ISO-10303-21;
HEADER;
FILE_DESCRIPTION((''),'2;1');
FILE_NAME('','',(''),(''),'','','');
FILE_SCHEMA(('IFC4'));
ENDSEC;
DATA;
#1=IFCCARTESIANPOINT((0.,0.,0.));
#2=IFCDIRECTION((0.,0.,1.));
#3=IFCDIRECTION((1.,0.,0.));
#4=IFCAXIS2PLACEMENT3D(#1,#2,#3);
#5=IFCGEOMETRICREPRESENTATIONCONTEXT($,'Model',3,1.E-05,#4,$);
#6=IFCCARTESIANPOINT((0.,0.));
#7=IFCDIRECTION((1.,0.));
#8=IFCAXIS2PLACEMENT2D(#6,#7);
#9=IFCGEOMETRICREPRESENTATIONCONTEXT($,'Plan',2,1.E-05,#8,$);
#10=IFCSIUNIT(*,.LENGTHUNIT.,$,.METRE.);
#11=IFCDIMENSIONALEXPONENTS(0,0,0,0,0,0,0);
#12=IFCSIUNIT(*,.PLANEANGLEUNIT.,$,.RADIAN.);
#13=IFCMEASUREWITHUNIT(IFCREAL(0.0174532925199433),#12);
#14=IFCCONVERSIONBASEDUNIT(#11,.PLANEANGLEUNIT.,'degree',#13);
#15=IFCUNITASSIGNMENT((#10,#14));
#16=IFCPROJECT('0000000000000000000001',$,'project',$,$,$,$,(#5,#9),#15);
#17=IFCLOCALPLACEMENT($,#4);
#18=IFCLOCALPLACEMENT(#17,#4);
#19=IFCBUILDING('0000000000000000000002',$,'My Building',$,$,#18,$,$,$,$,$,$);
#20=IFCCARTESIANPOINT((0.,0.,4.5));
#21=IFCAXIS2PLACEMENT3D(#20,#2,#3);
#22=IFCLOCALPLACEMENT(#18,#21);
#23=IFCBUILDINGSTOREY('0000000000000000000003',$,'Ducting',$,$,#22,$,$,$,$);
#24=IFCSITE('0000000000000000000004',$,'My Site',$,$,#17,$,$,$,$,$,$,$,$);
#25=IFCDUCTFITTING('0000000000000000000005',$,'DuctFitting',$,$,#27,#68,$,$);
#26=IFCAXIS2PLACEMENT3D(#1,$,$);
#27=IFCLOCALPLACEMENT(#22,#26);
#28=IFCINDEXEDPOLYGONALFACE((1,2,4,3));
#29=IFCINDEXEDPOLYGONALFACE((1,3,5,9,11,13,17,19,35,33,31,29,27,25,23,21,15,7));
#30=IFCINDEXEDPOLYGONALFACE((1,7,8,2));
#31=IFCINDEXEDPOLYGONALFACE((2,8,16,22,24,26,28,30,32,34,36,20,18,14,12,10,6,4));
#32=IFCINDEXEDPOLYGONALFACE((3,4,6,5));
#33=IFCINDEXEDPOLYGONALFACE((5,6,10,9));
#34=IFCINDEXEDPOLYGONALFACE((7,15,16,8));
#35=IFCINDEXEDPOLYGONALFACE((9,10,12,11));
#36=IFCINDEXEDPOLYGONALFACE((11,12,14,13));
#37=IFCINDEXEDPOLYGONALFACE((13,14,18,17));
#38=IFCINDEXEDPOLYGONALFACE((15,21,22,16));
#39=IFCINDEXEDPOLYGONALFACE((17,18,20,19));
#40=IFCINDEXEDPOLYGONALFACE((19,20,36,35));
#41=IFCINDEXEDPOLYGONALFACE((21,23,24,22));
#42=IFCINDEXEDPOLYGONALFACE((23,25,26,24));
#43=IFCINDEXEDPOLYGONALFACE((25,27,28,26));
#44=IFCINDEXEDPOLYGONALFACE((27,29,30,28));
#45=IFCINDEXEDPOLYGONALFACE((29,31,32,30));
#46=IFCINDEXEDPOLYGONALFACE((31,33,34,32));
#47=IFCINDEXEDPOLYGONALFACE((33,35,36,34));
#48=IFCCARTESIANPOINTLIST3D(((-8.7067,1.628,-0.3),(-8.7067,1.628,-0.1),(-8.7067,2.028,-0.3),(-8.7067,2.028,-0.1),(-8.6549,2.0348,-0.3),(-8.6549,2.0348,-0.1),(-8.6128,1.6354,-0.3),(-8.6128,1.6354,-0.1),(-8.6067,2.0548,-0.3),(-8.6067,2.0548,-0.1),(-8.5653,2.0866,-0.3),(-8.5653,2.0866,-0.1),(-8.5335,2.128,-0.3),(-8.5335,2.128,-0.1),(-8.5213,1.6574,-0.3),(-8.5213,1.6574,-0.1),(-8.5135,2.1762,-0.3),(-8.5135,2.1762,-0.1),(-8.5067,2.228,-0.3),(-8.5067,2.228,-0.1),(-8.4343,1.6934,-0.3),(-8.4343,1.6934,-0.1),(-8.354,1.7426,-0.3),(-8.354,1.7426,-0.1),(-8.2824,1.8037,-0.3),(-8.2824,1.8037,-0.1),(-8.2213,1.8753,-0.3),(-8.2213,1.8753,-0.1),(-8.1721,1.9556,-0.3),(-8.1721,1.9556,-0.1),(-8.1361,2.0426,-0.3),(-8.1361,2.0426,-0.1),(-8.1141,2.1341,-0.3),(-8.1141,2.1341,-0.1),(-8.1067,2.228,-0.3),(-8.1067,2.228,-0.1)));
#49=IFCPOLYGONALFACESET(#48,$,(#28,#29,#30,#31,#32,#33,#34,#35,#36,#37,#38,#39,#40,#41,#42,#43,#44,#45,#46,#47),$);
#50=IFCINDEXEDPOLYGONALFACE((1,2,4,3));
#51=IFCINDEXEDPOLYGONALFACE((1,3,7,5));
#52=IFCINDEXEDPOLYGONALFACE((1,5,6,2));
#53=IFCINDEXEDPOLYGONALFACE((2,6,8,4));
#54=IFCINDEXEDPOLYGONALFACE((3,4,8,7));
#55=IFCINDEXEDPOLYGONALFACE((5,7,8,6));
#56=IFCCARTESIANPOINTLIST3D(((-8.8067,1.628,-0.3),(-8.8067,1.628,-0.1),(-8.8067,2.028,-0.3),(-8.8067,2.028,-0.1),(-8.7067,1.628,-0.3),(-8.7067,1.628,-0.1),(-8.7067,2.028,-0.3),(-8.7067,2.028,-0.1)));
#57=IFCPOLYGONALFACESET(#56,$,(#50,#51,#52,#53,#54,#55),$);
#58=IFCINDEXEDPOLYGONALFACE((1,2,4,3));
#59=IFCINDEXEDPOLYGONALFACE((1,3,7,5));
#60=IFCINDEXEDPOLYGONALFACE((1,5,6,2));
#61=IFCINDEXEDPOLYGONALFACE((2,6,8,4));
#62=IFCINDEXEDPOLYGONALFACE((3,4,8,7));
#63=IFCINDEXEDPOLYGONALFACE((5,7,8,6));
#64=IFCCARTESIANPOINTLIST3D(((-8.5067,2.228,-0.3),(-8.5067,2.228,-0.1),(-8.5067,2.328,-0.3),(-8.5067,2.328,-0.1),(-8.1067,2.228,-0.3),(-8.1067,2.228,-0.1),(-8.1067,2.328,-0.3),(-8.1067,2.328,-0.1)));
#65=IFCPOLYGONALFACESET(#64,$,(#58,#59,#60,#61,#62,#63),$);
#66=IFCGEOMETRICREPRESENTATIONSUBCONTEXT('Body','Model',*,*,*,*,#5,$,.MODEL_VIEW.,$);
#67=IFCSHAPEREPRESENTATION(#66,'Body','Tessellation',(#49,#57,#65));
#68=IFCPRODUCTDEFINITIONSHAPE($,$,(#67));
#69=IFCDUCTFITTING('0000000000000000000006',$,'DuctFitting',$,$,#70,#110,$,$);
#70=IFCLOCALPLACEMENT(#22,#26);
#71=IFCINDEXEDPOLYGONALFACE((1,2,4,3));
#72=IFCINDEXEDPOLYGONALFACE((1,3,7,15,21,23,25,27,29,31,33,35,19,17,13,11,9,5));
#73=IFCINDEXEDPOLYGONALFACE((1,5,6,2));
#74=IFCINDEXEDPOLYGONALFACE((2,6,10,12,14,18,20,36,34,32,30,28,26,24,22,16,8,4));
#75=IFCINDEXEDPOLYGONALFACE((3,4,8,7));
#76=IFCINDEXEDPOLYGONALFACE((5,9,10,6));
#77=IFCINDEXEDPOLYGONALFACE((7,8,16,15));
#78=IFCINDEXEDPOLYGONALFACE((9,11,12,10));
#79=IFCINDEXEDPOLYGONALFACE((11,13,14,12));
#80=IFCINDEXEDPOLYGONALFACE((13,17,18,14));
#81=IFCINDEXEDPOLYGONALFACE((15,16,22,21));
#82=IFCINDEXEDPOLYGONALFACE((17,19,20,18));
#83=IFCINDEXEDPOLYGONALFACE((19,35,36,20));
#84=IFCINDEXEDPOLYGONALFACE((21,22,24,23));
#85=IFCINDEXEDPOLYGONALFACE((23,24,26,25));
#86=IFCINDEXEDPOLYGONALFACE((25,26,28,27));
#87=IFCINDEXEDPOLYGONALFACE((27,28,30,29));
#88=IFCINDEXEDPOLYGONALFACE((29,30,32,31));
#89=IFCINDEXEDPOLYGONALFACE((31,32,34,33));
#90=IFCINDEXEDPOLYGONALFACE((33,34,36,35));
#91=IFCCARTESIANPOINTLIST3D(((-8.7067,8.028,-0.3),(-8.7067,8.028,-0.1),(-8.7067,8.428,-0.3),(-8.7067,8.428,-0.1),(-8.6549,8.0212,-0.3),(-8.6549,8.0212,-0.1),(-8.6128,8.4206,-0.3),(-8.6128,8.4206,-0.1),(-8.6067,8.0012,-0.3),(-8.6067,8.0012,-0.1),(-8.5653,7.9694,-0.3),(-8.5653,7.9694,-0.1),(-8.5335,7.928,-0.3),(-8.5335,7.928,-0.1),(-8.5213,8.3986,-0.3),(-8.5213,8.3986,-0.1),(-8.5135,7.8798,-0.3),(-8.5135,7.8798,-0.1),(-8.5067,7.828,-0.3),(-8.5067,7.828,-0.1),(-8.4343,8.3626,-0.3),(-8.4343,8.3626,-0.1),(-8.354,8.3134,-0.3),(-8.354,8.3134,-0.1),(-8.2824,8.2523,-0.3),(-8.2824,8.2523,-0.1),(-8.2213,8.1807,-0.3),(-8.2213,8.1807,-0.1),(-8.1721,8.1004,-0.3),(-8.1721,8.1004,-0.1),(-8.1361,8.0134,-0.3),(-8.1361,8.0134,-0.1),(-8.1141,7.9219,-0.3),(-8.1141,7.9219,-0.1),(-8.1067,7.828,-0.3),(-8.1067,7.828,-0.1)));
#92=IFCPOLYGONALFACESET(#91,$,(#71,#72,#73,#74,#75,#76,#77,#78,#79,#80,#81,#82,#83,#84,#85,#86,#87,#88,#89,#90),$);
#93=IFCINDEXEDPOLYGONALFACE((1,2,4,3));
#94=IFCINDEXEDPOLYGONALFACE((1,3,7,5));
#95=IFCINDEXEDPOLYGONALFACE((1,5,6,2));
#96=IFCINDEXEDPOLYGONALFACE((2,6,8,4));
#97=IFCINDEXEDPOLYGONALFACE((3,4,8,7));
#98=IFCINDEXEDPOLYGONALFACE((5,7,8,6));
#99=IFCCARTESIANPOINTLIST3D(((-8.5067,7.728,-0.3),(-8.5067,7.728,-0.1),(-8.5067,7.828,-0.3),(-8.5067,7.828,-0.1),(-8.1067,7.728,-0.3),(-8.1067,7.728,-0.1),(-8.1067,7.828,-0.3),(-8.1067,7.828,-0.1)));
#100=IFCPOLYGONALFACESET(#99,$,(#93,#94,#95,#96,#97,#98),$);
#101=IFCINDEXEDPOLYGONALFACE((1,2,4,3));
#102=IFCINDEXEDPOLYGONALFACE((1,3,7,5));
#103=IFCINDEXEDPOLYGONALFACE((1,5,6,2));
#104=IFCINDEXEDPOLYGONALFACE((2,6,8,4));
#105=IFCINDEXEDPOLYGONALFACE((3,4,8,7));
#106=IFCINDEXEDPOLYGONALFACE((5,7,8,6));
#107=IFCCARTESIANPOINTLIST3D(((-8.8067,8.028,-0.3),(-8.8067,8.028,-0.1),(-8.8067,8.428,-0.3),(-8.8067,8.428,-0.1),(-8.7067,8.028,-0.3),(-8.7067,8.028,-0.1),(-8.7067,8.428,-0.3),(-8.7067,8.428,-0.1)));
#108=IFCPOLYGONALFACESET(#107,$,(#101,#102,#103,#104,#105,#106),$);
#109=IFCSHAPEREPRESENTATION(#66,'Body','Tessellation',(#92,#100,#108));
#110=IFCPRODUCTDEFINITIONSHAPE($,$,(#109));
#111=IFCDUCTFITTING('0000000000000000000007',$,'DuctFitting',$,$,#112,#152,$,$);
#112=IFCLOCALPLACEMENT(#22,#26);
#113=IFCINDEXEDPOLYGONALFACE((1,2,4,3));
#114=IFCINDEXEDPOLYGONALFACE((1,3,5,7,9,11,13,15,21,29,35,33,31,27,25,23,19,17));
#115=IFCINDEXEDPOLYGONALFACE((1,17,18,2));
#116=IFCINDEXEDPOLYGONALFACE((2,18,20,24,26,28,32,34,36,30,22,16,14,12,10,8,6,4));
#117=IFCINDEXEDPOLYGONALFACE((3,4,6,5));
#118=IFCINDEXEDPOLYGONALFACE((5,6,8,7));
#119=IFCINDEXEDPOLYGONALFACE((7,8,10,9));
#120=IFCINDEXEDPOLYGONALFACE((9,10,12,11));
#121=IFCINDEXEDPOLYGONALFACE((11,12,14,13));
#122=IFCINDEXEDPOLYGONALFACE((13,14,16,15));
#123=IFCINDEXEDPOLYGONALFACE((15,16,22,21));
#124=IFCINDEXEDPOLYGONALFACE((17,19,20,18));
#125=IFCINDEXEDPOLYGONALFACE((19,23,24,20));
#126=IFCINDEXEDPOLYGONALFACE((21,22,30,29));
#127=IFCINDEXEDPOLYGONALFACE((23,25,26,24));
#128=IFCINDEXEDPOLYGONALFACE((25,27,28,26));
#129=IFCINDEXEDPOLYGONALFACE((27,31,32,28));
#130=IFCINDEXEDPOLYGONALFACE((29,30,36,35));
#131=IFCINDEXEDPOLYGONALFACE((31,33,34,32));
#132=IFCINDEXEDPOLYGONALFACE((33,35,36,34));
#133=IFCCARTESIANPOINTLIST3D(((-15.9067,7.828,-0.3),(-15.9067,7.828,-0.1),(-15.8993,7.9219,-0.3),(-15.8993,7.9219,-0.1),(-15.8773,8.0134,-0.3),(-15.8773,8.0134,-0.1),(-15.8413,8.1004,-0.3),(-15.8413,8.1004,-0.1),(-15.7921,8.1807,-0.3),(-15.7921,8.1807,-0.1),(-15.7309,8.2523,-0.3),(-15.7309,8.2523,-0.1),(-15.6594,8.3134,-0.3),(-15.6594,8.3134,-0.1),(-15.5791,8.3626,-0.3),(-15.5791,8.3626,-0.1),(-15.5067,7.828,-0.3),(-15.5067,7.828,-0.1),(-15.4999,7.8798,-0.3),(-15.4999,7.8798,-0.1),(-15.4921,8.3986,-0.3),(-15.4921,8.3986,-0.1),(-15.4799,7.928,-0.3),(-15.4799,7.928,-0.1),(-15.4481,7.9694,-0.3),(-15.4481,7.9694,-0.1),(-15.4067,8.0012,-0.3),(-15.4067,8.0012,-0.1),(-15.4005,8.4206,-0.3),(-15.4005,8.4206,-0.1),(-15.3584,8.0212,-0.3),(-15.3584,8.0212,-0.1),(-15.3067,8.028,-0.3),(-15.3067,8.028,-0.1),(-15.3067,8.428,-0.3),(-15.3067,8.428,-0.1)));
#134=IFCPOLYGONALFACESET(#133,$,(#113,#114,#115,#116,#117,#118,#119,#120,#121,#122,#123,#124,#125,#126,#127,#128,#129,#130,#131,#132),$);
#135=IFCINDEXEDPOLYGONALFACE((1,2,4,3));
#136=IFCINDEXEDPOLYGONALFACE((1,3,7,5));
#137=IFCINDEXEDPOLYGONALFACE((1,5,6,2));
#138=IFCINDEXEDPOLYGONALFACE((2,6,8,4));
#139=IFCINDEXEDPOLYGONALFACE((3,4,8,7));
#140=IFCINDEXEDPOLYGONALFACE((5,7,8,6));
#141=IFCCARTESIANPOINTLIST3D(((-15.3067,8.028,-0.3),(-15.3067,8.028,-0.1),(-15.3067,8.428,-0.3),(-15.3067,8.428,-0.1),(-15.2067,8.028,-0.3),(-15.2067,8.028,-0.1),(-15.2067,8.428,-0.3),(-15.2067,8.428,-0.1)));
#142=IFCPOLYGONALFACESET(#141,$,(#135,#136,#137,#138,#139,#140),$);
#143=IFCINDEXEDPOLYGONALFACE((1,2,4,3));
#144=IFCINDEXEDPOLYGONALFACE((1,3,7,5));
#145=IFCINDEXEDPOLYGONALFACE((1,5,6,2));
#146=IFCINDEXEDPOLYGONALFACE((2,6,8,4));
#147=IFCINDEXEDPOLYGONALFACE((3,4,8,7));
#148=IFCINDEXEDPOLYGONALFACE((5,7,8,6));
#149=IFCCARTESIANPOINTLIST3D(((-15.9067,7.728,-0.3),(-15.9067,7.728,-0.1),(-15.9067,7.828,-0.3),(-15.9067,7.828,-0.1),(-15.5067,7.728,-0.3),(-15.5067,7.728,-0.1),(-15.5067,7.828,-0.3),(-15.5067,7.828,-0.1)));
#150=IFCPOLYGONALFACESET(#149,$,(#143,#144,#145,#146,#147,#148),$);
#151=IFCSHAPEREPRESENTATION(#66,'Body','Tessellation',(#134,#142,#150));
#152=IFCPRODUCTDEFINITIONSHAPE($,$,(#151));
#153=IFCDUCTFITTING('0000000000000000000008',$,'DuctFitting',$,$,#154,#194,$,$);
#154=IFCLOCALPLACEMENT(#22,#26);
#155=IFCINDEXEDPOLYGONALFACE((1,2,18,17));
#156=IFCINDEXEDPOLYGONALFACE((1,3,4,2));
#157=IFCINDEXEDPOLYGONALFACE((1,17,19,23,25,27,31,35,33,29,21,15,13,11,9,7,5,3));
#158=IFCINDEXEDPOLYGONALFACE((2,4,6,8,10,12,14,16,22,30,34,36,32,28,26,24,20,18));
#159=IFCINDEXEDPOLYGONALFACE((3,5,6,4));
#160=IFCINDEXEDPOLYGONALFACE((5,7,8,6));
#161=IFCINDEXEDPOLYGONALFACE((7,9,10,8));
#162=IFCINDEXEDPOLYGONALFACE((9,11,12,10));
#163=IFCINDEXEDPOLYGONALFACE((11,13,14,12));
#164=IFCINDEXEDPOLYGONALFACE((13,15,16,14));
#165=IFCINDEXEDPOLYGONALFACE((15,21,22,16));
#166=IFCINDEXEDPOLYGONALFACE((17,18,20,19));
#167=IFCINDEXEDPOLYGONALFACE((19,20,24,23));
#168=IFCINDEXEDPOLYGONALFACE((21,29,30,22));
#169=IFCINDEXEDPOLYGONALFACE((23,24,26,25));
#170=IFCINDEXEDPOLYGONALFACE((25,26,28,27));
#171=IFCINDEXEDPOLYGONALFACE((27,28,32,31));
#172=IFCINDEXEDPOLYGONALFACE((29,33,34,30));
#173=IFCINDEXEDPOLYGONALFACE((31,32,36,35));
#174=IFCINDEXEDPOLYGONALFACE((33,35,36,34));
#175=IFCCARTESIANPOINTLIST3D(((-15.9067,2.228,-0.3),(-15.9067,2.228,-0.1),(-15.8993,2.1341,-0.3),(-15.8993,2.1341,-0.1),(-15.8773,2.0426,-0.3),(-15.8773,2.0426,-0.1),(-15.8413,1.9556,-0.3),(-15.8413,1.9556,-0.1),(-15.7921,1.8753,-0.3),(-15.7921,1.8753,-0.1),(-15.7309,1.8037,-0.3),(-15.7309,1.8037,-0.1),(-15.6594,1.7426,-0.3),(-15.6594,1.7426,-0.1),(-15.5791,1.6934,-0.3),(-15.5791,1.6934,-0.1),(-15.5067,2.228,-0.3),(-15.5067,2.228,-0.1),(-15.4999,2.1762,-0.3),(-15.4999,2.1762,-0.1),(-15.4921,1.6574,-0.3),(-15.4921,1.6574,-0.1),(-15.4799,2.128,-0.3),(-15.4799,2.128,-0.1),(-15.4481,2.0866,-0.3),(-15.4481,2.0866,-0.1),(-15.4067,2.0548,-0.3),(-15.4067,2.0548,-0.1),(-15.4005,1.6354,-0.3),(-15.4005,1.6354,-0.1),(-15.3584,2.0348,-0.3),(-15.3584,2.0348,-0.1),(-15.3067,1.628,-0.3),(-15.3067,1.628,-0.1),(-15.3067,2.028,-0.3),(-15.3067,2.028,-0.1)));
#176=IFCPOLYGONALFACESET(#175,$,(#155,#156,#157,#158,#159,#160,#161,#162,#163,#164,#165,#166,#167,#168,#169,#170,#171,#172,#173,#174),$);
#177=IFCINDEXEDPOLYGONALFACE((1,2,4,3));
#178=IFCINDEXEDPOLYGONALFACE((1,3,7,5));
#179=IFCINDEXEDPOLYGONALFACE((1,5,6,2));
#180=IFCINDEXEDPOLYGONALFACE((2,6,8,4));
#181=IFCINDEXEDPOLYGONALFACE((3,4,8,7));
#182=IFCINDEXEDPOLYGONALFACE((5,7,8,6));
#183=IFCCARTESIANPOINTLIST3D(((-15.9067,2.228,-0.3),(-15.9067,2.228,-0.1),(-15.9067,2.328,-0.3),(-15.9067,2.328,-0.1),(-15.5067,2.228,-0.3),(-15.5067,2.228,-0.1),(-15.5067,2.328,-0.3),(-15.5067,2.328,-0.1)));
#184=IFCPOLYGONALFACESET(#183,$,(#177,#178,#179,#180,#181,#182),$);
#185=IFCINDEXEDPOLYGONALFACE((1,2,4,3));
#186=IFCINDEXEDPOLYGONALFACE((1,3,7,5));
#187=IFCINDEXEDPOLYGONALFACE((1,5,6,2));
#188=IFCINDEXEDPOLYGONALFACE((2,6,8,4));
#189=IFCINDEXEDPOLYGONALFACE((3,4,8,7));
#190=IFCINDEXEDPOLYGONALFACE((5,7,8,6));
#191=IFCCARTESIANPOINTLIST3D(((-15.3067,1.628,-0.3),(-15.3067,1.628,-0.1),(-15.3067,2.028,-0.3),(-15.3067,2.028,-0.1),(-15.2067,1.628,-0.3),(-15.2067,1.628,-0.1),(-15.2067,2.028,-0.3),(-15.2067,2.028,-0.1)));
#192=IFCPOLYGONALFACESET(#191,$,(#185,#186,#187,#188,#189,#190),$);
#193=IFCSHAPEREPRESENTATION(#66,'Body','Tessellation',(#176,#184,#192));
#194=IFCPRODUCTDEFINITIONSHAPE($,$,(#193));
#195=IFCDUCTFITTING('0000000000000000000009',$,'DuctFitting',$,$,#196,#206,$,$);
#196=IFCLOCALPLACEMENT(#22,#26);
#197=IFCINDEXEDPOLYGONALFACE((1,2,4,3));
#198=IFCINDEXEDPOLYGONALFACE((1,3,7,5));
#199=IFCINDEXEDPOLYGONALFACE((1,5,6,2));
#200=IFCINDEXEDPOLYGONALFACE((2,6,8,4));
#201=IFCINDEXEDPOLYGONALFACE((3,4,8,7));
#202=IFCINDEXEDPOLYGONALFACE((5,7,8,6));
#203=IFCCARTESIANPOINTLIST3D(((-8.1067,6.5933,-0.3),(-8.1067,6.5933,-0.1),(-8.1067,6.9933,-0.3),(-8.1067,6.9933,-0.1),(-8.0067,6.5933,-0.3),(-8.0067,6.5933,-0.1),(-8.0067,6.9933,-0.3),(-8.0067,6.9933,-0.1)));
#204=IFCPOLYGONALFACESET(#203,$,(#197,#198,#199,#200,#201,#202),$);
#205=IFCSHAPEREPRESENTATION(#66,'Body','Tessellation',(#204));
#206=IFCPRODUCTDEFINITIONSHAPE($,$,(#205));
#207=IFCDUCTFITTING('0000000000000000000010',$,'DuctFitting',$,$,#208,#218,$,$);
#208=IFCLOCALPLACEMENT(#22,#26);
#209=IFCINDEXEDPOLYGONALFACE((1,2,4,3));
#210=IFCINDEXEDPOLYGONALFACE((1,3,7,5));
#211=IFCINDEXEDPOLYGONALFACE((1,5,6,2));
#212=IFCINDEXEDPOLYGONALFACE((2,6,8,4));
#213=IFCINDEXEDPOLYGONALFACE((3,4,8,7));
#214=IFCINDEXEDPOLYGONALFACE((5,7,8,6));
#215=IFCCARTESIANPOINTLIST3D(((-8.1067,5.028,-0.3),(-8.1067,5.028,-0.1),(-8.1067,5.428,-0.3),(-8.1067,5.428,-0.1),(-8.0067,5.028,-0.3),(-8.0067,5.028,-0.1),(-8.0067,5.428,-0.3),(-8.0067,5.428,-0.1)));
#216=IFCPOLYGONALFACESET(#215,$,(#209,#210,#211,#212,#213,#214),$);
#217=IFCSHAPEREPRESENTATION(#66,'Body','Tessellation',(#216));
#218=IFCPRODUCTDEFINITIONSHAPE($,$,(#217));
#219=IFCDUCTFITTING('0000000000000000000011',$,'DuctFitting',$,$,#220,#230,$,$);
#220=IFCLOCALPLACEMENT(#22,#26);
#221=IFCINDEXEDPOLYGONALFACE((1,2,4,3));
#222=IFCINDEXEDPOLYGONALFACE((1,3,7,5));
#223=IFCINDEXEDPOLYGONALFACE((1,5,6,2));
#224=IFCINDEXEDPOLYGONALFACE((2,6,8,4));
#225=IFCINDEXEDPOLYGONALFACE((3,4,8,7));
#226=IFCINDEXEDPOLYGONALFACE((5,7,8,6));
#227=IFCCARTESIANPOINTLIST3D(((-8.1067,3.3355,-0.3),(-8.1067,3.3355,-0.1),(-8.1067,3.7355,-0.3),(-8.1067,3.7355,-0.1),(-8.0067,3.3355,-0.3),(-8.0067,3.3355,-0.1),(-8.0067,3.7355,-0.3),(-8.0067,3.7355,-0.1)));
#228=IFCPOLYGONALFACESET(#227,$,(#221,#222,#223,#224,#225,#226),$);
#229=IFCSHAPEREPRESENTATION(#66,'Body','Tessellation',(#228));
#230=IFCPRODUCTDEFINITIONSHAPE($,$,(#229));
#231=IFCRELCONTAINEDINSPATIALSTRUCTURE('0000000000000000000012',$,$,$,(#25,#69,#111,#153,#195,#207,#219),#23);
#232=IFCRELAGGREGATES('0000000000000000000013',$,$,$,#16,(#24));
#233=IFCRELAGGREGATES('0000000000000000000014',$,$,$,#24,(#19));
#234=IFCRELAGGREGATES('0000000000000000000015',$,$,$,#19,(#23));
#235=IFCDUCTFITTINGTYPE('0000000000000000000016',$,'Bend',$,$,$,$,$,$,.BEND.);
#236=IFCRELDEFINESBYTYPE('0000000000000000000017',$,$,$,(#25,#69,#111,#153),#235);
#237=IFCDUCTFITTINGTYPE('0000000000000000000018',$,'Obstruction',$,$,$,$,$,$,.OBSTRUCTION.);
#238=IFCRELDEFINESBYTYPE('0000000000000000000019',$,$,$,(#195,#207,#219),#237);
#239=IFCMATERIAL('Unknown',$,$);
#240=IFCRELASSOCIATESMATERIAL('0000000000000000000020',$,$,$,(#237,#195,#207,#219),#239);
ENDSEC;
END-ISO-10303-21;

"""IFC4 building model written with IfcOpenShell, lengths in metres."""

from ifc_helpers import new_model, entity, si_unit, converted_unit, frame, origin_with_axes, origin_2d_with_axis, place, context, subcontext, project, spatial, line, arc, indexed_curve, rectangle, outline, extrude, source, transform, mapped, material, material_profile, profile_set, profile_usage, type_object, type_shapes, element, save


model = new_model("IFC4")

# Units and contexts
model_context = context("Model", 3, precision=1e-05, world=origin_with_axes())
plan_context = context("Plan", 2, precision=1e-05, world=origin_2d_with_axis())
body_context = subcontext(model_context, "Body", "Model", "MODEL_VIEW")
ifc_project = project(units=[si_unit("LENGTHUNIT", "METRE"), converted_unit("PLANEANGLEUNIT", "degree", entity("IfcReal", 0.0174532925199433), si_unit("PLANEANGLEUNIT", "RADIAN"), dimensions=[0, 0, 0, 0, 0, 0, 0])], contexts=[model_context, plan_context])

# Site, building, storey
site_placement = place(None, origin_with_axes())
site = spatial("IfcSite", under=ifc_project, at=site_placement, Name="My Site")
building_placement = place(site_placement, origin_with_axes())
building = spatial("IfcBuilding", under=site, at=building_placement, Name="My Building")
storey_placement = place(building_placement, frame((0.0, 0.0, 4.5), z_axis=(0.0, 0.0, 1.0), x_axis=(1.0, 0.0, 0.0)))
storey = spatial("IfcBuildingStorey", under=building, at=storey_placement, Name="Ducting")

# Shared definitions
ifc_material = material(Name="Unknown")

# Duct fittings
duct_fitting_type_1 = type_object("IfcDuctFittingType", Name="Bend", PredefinedType="BEND")
shared_shape = source(origin_with_axes(), body_context, "Body", "SweptSolid", [
    extrude(outline(indexed_curve([(0.2, 0.0), (0.2586, 0.1414), (0.4, 0.2), (0.4, 0.6), (-0.0243, 0.4243), (-0.2, 0.0)], segments=[arc(1, 2, 3), line(3, 4), arc(4, 5, 6), line(6, 1)])), frame((0.0, -0.1, 0.1), z_axis=(0.0, -1.0, 0.0), x_axis=(1.0, 0.0, 0.0)), (0.0, 0.0, -1.0), 0.2),
    extrude(rectangle(XDim=0.4, YDim=0.2), origin_with_axes(), (0.0, 0.0, 1.0), 0.1),
    extrude(rectangle(XDim=0.4, YDim=0.2), frame((0.4, 0.0, 0.5), z_axis=(1.0, 0.0, 0.0), x_axis=(0.0, 0.0, 1.0)), (0.0, 0.0, 1.0), 0.1),
])
type_shapes(duct_fitting_type_1, [shared_shape])
for number, where, z_axis, x_axis, name in (
    (1, (-8.8067, 1.828, -0.2), (1.0, 0.0, 0.0), (0.0, 1.0, 0.0), "DuctFitting"),
    (2, (-8.3067, 7.728, -0.2), (0.0, 1.0, 0.0), (-1.0, 0.0, 0.0), "DuctFitting"),
    (3, (-15.2067, 8.228, -0.2), (-1.0, 0.0, 0.0), (0.0, -1.0, 0.0), "DuctFitting"),
    (4, (-15.7067, 2.328, -0.2), (0.0, -1.0, 0.0), (1.0, 0.0, 0.0), "DuctFitting"),
):
    element("IfcDuctFitting", number, at=place(storey_placement, frame(where, z_axis=z_axis, x_axis=x_axis)), inside=storey, type_object=duct_fitting_type_1, Name=name, context=body_context, shape_type="MappedRepresentation", body=[
        mapped(shared_shape, transform((0.0, 0.0, 0.0), x_axis=(1.0, 0.0, 0.0), y_axis=(0.0, 1.0, 0.0), z_axis=(0.0, 0.0, 1.0), scale=1.0)),
    ])
ifc_material_profile_1 = material_profile(ifc_material, rectangle(XDim=0.4, YDim=0.2))
ifc_profile_set_1 = profile_set([ifc_material_profile_1])
ifc_profile_usage_1 = profile_usage(ifc_profile_set_1, cardinal=5)
duct_fitting_type_2 = type_object("IfcDuctFittingType", Name="Obstruction", PredefinedType="OBSTRUCTION", material=ifc_profile_set_1)
duct_fitting_1_placement = place(storey_placement, frame((-8.0067, 6.7933, -0.2), z_axis=(-1.0, 0.0, 0.0), x_axis=(0.0, -1.0, 0.0)))
element("IfcDuctFitting", 5, at=duct_fitting_1_placement, inside=storey, type_object=duct_fitting_type_2, material=ifc_profile_usage_1, Name="DuctFitting", context=body_context, shape_type="SweptSolid", body=[
    extrude(rectangle(XDim=0.4, YDim=0.2), origin_with_axes(), (0.0, 0.0, 1.0), 0.1),
])
ifc_profile_usage_2 = profile_usage(ifc_profile_set_1, cardinal=5)
duct_fitting_2_placement = place(storey_placement, frame((-8.0067, 5.228, -0.2), z_axis=(-1.0, 0.0, 0.0), x_axis=(0.0, -1.0, 0.0)))
element("IfcDuctFitting", 6, at=duct_fitting_2_placement, inside=storey, type_object=duct_fitting_type_2, material=ifc_profile_usage_2, Name="DuctFitting", context=body_context, shape_type="SweptSolid", body=[
    extrude(rectangle(XDim=0.4, YDim=0.2), origin_with_axes(), (0.0, 0.0, 1.0), 0.1),
])
ifc_profile_usage_3 = profile_usage(ifc_profile_set_1, cardinal=5)
duct_fitting_3_placement = place(storey_placement, frame((-8.0067, 3.5355, -0.2), z_axis=(-1.0, 0.0, 0.0), x_axis=(0.0, -1.0, 0.0)))
element("IfcDuctFitting", 7, at=duct_fitting_3_placement, inside=storey, type_object=duct_fitting_type_2, material=ifc_profile_usage_3, Name="DuctFitting", context=body_context, shape_type="SweptSolid", body=[
    extrude(rectangle(XDim=0.4, YDim=0.2), origin_with_axes(), (0.0, 0.0, 1.0), 0.1),
])

save(model, "model.ifc")
